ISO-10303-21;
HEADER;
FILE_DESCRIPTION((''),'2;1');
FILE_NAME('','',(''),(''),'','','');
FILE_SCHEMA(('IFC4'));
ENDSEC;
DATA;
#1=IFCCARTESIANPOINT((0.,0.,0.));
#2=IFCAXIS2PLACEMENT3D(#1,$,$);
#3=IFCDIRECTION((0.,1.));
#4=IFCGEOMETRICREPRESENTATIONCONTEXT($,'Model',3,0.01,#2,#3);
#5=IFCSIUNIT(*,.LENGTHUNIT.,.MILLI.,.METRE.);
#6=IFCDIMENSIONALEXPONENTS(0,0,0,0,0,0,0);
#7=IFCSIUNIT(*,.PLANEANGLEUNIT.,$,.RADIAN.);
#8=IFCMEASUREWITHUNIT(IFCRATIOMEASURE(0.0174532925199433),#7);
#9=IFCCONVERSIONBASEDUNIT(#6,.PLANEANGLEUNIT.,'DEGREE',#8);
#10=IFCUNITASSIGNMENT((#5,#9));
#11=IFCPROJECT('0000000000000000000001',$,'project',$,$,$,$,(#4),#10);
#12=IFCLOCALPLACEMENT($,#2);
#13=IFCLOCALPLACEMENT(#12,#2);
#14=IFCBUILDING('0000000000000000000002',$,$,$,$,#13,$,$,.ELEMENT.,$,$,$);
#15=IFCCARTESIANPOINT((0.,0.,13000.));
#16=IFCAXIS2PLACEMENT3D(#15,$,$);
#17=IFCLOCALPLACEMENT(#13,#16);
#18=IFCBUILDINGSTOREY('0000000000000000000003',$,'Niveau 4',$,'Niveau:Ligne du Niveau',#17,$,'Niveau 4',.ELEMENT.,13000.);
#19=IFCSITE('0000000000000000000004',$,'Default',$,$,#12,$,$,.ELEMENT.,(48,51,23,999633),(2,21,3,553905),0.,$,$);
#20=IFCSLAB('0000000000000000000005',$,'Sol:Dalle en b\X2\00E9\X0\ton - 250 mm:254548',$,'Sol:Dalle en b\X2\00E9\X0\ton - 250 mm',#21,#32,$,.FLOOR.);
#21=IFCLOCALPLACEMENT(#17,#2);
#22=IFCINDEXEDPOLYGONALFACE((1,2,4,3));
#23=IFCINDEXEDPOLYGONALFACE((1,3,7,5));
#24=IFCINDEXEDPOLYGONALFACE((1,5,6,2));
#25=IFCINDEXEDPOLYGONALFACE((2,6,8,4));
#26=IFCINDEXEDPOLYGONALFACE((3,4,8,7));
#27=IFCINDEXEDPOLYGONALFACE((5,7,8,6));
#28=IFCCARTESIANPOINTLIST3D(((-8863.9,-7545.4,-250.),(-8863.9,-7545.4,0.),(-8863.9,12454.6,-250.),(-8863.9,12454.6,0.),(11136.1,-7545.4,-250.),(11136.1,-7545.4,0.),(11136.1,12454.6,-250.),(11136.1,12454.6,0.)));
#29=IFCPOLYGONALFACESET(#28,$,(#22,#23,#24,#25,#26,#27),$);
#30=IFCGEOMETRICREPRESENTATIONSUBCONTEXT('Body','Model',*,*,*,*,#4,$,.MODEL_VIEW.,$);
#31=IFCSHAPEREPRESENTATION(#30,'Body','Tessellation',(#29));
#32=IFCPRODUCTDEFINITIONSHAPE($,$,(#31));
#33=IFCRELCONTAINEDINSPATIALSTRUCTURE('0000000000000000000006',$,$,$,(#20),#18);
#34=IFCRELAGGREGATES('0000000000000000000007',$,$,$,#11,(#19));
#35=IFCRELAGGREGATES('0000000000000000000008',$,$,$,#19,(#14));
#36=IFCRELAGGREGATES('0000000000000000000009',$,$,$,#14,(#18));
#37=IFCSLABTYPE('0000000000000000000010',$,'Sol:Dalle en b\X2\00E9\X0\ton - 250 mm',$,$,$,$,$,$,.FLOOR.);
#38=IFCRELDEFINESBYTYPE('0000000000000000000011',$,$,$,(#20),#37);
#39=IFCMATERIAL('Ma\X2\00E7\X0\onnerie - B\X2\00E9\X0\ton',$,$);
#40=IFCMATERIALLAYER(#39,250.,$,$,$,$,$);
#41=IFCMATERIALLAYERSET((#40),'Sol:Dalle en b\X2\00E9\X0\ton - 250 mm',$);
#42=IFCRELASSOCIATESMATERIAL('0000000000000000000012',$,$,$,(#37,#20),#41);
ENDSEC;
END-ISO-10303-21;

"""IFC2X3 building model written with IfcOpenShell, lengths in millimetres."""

from ifc_helpers import new_model, entity, si_unit, converted_unit, direction, frame, origin, origin_2d_with_axis, place, context, subcontext, project, spatial, rectangle, extrude, material, layer, layer_set, layer_usage, type_object, element, save


model = new_model("IFC2X3")

# Units and contexts
model_context = context("Model", 3, precision=0.01, world=origin(), true_north=direction((0.0, 1.0)))
body_context = subcontext(model_context, "Body", "Model", "MODEL_VIEW")
ifc_project = project(units=[si_unit("LENGTHUNIT", "METRE", prefix="MILLI"), converted_unit("PLANEANGLEUNIT", "DEGREE", entity("IfcRatioMeasure", 0.0174532925199433), si_unit("PLANEANGLEUNIT", "RADIAN"), dimensions=[0, 0, 0, 0, 0, 0, 0])], contexts=[model_context])

# Site, building, storey
site_placement = place(None, origin())
site = spatial("IfcSite", under=ifc_project, at=site_placement, Name="Default", CompositionType="ELEMENT", RefLatitude=(48, 51, 23, 999633), RefLongitude=(2, 21, 3, 553905), RefElevation=0.0)
building_placement = place(site_placement, origin())
building = spatial("IfcBuilding", under=site, at=building_placement, CompositionType="ELEMENT")
storey_placement = place(building_placement, frame((0.0, 0.0, 13000.0)))
storey = spatial("IfcBuildingStorey", under=building, at=storey_placement, Name="Niveau 4", ObjectType="Niveau:Ligne du Niveau", LongName="Niveau 4", CompositionType="ELEMENT", Elevation=13000.0)

# Slab
ifc_material = material(Name="Maçonnerie - Béton")
ifc_layer = layer(ifc_material, 250.0)
ifc_layer_set = layer_set([ifc_layer], Name="Sol:Dalle en béton - 250 mm")
ifc_layer_usage = layer_usage(ifc_layer_set, "AXIS3", "POSITIVE", 0.0)
slab_type = type_object("IfcSlabType", Name="Sol:Dalle en béton - 250 mm", PredefinedType="FLOOR", material=ifc_layer_set)
slab_placement = place(storey_placement, origin())
element("IfcSlab", 1, at=slab_placement, inside=storey, type_object=slab_type, material=ifc_layer_usage, Name="Sol:Dalle en béton - 250 mm:254548", ObjectType="Sol:Dalle en béton - 250 mm", PredefinedType="FLOOR", context=body_context, shape_type="SweptSolid", body=[
    extrude(rectangle(XDim=20000.0, YDim=20000.0, at=origin_2d_with_axis()), frame((1136.1, 2454.6, 0.0), z_axis=(0.0, 0.0, -1.0), x_axis=(0.0, 1.0, 0.0)), (0.0, 0.0, 1.0), 250.0),
])

save(model, "model.ifc")
